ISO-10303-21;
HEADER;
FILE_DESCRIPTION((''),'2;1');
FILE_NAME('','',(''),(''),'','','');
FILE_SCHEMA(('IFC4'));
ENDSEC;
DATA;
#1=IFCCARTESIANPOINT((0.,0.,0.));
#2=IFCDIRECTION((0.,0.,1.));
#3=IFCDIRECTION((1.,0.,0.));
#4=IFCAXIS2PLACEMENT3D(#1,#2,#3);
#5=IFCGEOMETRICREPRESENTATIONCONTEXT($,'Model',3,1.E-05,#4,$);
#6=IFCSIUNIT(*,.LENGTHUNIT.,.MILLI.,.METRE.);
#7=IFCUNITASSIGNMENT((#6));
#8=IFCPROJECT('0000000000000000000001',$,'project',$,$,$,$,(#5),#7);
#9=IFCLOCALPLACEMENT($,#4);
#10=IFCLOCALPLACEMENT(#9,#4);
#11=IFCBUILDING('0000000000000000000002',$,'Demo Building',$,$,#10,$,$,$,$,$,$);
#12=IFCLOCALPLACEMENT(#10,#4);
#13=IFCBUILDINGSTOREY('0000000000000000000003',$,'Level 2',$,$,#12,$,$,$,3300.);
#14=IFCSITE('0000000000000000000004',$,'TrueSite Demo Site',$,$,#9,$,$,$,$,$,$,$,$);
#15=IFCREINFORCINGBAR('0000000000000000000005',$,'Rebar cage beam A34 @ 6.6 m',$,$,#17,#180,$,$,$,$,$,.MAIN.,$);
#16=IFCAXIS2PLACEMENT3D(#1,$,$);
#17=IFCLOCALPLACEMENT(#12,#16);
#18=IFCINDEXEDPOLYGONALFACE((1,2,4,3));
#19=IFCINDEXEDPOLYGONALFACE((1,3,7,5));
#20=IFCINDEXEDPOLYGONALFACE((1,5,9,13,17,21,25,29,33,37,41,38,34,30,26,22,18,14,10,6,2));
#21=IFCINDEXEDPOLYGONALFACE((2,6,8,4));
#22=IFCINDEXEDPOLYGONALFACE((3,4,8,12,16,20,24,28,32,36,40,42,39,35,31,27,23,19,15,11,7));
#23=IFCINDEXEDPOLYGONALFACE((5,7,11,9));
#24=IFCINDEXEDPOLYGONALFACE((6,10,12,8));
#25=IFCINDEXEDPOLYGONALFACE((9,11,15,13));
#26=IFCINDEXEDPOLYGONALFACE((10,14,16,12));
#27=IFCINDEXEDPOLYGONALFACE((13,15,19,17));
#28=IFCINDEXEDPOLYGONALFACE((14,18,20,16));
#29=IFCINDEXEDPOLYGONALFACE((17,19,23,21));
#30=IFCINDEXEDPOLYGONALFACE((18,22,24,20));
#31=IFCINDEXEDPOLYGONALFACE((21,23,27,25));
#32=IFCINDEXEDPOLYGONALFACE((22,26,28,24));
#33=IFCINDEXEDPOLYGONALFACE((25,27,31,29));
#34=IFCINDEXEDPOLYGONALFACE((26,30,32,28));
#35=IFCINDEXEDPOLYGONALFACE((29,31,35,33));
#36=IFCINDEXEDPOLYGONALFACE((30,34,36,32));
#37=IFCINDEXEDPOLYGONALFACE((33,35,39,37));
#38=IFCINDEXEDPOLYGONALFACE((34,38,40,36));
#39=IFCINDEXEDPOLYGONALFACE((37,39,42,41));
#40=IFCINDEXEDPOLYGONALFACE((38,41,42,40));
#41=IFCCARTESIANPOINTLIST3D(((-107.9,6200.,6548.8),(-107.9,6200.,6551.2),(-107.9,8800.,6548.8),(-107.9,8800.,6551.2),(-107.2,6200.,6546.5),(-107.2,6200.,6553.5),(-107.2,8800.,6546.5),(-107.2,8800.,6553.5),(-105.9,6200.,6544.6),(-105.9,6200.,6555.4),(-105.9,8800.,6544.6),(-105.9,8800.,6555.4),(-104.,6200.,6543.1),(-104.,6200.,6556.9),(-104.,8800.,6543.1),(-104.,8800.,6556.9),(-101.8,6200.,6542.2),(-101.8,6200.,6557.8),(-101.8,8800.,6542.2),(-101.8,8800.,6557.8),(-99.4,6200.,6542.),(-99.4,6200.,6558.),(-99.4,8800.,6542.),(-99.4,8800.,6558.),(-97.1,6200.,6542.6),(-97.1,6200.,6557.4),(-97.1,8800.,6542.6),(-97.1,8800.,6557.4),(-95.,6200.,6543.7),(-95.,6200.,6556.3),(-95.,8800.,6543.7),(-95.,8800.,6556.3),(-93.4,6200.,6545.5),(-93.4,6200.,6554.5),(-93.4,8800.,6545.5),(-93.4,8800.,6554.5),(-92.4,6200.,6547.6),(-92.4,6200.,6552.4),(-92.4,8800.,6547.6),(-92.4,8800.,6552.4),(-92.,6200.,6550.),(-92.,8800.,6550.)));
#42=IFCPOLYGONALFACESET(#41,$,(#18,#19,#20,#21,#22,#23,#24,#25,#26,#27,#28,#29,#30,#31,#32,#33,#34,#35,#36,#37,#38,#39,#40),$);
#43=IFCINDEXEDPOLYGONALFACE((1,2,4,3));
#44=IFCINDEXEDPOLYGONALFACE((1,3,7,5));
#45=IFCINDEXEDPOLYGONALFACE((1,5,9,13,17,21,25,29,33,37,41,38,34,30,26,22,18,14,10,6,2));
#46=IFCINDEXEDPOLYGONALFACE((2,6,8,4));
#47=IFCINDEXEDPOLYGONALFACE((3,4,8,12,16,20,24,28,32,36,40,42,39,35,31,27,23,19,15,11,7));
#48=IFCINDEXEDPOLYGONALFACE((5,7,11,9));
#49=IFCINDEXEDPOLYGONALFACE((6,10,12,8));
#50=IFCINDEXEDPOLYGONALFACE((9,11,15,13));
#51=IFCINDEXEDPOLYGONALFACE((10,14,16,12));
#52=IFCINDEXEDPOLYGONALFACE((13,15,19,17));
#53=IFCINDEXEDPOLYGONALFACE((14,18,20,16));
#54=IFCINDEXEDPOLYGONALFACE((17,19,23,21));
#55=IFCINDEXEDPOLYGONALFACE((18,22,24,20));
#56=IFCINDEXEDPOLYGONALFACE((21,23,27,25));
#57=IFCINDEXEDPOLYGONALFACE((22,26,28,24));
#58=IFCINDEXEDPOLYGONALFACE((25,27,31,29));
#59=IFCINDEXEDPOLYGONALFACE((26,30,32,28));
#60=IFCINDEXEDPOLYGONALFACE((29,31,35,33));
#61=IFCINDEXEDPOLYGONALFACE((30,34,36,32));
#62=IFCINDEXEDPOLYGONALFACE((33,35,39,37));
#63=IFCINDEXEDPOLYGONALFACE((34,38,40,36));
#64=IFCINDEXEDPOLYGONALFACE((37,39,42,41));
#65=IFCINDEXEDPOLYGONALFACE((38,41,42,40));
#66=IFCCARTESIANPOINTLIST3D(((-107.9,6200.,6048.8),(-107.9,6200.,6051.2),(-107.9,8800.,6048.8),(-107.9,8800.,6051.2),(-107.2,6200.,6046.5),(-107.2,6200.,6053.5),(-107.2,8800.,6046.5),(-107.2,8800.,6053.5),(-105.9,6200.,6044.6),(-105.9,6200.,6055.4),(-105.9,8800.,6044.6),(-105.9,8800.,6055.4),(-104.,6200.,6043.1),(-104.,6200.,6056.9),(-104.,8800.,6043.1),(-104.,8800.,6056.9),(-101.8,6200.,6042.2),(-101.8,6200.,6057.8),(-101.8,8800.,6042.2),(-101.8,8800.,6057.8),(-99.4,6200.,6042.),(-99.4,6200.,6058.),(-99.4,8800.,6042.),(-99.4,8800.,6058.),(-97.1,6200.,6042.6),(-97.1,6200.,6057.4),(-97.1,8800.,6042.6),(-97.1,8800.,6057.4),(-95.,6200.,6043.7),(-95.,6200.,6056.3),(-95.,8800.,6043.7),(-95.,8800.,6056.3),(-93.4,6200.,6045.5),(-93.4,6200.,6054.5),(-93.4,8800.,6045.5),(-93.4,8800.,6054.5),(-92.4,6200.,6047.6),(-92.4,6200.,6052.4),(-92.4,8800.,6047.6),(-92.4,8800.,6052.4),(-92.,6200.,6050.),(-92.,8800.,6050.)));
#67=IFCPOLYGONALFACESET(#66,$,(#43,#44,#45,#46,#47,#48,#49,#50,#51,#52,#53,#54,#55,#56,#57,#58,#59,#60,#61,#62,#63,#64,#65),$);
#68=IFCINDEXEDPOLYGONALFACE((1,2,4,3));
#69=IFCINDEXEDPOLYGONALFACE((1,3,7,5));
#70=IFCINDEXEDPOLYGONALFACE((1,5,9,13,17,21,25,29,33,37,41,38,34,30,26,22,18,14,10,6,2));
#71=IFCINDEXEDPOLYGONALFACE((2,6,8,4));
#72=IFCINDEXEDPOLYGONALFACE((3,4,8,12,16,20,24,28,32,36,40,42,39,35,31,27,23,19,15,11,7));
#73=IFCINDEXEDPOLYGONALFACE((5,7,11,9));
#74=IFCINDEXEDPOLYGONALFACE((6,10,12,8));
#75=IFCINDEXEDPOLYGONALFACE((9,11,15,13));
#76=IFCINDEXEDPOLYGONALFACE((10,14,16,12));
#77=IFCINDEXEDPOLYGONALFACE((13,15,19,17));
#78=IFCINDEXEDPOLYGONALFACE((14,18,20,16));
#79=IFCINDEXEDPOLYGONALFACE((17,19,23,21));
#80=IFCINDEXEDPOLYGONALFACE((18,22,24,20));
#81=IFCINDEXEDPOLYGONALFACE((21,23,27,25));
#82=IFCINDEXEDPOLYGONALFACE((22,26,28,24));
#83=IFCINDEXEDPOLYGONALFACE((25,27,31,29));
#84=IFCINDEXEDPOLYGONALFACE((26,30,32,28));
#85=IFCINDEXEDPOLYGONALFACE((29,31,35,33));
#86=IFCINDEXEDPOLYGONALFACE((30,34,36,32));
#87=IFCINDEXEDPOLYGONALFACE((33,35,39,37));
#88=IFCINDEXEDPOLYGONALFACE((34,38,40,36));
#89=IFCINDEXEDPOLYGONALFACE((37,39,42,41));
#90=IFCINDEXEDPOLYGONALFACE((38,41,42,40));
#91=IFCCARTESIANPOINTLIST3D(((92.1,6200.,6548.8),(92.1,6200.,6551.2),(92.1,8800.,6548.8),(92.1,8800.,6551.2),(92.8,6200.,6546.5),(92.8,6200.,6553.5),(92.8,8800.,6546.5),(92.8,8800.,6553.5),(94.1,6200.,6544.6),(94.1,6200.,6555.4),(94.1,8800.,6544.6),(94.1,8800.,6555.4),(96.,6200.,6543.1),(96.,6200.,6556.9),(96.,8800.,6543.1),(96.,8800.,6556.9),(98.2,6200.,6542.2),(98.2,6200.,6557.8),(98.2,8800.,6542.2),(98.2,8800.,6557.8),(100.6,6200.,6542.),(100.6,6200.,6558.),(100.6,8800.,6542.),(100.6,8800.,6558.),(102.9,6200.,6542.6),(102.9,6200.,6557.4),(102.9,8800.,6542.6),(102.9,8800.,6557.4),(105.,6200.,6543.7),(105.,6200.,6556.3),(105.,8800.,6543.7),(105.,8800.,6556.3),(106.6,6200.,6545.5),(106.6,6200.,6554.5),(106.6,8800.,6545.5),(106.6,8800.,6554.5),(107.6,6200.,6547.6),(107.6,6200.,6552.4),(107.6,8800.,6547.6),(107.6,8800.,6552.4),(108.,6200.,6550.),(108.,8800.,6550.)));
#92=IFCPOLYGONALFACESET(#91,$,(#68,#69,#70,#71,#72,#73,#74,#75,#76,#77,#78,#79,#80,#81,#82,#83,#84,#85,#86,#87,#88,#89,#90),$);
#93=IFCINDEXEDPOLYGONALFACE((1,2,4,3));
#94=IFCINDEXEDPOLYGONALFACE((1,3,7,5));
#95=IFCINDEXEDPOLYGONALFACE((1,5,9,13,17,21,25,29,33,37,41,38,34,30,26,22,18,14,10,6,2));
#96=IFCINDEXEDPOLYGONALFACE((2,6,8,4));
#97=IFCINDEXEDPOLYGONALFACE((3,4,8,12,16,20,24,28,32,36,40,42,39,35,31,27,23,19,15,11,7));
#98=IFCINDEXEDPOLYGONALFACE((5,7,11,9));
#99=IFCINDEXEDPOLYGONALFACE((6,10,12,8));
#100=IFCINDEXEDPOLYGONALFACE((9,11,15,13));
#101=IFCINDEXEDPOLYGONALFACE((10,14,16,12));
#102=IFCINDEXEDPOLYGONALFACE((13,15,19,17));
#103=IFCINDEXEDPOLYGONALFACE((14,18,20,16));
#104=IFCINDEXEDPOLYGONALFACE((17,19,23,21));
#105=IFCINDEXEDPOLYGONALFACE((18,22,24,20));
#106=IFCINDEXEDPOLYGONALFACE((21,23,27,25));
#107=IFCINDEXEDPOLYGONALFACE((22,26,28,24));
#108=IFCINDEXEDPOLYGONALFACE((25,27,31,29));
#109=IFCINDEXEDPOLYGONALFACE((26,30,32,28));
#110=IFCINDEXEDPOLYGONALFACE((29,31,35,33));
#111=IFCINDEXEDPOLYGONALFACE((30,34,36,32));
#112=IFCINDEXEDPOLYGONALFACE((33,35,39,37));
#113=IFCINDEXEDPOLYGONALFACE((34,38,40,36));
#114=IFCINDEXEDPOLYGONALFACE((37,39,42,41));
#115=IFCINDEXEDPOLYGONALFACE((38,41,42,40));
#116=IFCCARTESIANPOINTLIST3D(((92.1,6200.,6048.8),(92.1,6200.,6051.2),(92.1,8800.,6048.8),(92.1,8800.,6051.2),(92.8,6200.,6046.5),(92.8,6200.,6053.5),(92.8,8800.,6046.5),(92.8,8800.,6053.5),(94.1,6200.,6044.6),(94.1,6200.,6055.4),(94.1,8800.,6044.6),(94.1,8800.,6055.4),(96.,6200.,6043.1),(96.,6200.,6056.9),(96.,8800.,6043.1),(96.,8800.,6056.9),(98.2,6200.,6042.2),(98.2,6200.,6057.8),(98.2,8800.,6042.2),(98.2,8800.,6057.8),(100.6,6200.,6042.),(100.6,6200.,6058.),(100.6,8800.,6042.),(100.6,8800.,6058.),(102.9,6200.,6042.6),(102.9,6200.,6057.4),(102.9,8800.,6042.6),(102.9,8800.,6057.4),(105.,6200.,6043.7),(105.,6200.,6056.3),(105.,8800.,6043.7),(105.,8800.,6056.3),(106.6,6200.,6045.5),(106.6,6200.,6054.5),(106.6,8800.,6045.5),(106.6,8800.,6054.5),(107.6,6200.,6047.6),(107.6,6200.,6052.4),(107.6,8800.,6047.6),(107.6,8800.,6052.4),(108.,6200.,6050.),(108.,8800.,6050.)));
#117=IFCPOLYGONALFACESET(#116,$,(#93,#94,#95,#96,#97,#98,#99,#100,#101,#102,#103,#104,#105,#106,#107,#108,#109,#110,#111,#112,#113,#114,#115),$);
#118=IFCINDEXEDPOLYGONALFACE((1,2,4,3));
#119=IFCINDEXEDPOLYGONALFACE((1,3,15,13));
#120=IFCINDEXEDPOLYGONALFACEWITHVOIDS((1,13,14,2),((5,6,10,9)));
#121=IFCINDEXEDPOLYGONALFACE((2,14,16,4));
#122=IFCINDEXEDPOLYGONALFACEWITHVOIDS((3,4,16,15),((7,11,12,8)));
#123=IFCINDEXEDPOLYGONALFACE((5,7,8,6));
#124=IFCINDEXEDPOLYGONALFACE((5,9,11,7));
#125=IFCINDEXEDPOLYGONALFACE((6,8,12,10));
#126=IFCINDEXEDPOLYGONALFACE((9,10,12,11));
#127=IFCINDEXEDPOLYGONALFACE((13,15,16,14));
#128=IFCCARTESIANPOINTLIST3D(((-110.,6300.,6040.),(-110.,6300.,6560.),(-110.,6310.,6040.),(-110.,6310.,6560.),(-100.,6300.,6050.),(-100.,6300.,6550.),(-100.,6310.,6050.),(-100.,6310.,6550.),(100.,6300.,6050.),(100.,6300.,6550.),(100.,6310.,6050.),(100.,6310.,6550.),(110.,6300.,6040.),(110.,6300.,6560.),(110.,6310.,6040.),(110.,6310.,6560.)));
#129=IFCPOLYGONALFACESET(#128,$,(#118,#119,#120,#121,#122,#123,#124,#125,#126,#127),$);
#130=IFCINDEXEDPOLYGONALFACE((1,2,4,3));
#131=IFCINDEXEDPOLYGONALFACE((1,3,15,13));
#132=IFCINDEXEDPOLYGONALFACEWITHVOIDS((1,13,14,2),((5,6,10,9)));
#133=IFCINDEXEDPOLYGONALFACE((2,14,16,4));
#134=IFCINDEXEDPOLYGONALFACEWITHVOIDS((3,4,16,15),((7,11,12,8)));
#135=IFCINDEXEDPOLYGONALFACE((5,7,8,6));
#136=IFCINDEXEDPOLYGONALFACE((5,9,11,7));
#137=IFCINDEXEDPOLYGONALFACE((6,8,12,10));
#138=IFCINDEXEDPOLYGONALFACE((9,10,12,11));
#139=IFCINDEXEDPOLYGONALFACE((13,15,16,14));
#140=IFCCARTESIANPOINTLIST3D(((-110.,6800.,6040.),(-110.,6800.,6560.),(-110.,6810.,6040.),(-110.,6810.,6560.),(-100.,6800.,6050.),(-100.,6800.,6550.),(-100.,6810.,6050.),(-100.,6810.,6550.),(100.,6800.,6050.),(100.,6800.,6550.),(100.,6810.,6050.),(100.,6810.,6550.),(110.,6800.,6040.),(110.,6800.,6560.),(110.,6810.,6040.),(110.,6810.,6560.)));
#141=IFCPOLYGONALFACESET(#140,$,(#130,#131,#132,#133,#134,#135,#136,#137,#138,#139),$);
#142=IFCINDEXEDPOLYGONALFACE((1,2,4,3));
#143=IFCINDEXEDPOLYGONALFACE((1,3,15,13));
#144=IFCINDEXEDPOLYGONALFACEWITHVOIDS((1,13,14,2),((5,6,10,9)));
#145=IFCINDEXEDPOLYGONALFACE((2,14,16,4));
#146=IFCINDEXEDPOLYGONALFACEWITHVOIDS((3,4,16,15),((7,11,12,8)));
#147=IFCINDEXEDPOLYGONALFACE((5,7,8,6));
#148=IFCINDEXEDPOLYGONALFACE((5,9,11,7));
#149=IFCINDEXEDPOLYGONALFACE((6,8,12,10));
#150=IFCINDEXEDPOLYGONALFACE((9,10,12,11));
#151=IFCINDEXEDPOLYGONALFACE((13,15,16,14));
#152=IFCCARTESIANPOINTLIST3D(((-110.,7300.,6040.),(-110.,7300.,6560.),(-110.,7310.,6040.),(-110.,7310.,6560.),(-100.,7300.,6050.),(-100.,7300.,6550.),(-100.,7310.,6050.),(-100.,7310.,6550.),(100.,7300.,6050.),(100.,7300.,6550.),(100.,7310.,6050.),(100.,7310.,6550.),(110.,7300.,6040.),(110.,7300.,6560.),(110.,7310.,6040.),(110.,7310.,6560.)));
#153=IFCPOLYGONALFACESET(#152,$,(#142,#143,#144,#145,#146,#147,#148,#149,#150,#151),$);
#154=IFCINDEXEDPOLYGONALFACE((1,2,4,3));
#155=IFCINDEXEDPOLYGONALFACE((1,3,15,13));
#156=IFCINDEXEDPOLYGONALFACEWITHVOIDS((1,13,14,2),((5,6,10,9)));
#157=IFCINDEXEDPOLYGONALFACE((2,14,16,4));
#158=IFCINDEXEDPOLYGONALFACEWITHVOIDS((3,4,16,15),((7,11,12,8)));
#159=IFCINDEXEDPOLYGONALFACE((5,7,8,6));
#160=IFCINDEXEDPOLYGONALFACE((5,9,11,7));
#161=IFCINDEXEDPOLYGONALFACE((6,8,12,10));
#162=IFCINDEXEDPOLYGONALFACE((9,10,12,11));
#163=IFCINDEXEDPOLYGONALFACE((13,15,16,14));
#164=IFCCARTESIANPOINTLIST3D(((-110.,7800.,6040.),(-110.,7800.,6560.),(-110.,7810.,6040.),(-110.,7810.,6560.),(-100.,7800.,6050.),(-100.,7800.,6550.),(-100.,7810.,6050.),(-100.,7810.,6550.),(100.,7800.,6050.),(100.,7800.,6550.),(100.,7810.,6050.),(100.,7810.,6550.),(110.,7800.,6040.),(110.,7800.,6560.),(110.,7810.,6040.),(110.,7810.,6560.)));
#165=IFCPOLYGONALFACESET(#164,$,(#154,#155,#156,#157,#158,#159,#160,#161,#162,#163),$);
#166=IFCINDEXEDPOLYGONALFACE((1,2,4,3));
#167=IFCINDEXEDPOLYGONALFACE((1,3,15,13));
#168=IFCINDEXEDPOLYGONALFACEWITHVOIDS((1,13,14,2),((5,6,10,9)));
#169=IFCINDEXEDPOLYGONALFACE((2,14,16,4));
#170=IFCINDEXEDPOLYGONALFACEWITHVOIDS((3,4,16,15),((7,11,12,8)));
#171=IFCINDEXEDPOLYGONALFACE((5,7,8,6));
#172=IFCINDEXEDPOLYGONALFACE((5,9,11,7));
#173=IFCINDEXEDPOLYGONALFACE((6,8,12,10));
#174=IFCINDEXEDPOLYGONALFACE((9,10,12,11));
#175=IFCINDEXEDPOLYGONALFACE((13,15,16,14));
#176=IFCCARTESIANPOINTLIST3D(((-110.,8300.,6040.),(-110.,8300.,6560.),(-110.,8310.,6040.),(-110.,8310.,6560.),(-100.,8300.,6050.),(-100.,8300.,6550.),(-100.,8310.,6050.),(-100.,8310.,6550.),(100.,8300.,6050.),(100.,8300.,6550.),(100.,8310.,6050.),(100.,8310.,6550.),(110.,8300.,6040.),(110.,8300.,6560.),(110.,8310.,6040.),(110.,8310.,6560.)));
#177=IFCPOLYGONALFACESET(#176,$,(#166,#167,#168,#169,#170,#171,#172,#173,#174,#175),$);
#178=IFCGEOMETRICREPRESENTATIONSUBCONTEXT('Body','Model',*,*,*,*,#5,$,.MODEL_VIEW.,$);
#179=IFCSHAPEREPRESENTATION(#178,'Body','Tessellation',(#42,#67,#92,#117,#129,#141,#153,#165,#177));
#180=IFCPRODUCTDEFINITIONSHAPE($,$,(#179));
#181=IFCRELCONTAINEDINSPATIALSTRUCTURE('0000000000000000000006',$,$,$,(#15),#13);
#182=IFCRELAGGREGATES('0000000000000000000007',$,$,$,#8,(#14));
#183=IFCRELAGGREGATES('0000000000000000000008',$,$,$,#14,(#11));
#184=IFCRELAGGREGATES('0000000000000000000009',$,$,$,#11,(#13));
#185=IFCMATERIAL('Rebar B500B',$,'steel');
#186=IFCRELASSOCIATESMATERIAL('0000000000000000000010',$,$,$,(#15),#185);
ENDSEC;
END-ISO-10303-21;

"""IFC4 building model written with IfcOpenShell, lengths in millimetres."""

from ifc_helpers import new_model, si_unit, frame, origin_with_axes, place, context, subcontext, project, spatial, hollow_rectangle, circle, extrude, material, element, save


model = new_model("IFC4")

# Units and contexts
model_context = context("Model", 3, precision=1e-05, world=origin_with_axes())
body_context = subcontext(model_context, "Body", "Model", "MODEL_VIEW")
ifc_project = project(units=[si_unit("LENGTHUNIT", "METRE", prefix="MILLI")], contexts=[model_context])

# Site, building, storey
site_placement = place(None, origin_with_axes())
site = spatial("IfcSite", under=ifc_project, at=site_placement, Name="TrueSite Demo Site")
building_placement = place(site_placement, origin_with_axes())
building = spatial("IfcBuilding", under=site, at=building_placement, Name="Demo Building")
storey_placement = place(building_placement, origin_with_axes())
storey = spatial("IfcBuildingStorey", under=building, at=storey_placement, Name="Level 2", Elevation=3300.0)

# Reinforcing bar
ifc_material_1 = material(Name="Rebar B500B", Category="steel")
reinforcing_bar_1_placement = place(storey_placement, frame((0.0, 6200.0, 6300.0), z_axis=(0.0, 1.0, 0.0), x_axis=(1.0, 0.0, 0.0)))
element("IfcReinforcingBar", 1, at=reinforcing_bar_1_placement, inside=storey, material=ifc_material_1, Name="Rebar cage beam A34 @ 6.6 m", PredefinedType="MAIN", context=body_context, shape_type="SweptSolid", body=[
    extrude(circle(Radius=8.0), frame((-100.0, -250.0, 0.0)), (0.0, 0.0, 1.0), 2600.0),
    extrude(circle(Radius=8.0), frame((-100.0, 250.0, 0.0)), (0.0, 0.0, 1.0), 2600.0),
    extrude(circle(Radius=8.0), frame((100.0, -250.0, 0.0)), (0.0, 0.0, 1.0), 2600.0),
    extrude(circle(Radius=8.0), frame((100.0, 250.0, 0.0)), (0.0, 0.0, 1.0), 2600.0),
    extrude(hollow_rectangle(XDim=220.0, YDim=520.0, WallThickness=10.0), frame((0.0, 0.0, 100.0)), (0.0, 0.0, 1.0), 10.0),
    extrude(hollow_rectangle(XDim=220.0, YDim=520.0, WallThickness=10.0), frame((0.0, 0.0, 600.0)), (0.0, 0.0, 1.0), 10.0),
    extrude(hollow_rectangle(XDim=220.0, YDim=520.0, WallThickness=10.0), frame((0.0, 0.0, 1100.0)), (0.0, 0.0, 1.0), 10.0),
    extrude(hollow_rectangle(XDim=220.0, YDim=520.0, WallThickness=10.0), frame((0.0, 0.0, 1600.0)), (0.0, 0.0, 1.0), 10.0),
    extrude(hollow_rectangle(XDim=220.0, YDim=520.0, WallThickness=10.0), frame((0.0, 0.0, 2100.0)), (0.0, 0.0, 1.0), 10.0),
])

save(model, "model.ifc")
